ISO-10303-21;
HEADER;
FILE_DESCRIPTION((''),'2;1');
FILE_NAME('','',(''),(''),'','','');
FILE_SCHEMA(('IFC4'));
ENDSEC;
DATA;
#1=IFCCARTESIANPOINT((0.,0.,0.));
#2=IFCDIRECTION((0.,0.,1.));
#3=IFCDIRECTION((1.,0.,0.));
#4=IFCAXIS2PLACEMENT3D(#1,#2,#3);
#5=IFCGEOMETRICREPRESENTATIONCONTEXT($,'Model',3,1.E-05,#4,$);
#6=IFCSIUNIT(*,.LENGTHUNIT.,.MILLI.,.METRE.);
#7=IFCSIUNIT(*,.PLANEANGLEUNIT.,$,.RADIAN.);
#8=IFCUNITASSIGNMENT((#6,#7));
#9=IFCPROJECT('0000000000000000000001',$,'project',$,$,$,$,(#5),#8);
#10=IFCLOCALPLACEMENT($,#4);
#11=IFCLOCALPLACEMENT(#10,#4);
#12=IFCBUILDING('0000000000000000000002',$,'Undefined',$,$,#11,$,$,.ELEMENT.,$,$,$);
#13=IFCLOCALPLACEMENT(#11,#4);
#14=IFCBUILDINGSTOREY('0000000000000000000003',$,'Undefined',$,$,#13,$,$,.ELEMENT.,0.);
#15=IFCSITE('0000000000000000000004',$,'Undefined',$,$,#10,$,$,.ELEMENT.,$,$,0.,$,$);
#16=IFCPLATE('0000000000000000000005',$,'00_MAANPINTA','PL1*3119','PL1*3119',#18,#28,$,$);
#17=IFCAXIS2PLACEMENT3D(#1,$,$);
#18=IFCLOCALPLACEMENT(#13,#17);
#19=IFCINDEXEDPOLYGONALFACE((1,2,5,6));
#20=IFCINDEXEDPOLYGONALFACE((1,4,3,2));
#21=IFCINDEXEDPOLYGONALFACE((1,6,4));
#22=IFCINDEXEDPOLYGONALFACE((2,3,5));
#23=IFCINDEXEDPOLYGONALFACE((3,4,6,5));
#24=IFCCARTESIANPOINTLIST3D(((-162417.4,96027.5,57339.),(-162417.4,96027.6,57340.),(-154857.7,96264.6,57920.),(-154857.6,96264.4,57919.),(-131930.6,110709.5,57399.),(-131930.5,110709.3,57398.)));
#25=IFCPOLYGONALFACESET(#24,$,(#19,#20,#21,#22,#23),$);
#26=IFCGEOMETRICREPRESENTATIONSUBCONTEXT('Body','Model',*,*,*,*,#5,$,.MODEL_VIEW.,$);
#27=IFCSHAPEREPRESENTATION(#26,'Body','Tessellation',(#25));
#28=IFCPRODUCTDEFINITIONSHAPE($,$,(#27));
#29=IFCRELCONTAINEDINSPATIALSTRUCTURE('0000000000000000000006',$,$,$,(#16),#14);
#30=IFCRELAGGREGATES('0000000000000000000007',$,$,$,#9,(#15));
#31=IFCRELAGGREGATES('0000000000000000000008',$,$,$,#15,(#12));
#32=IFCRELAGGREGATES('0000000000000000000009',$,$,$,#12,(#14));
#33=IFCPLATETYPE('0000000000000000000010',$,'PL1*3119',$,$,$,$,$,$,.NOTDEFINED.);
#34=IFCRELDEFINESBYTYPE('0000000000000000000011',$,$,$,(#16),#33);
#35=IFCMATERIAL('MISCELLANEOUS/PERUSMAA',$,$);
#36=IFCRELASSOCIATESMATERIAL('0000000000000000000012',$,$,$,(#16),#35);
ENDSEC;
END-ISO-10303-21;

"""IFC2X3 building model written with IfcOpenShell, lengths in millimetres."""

from ifc_helpers import new_model, si_unit, frame, origin_with_axes, place, context, subcontext, project, spatial, polyline, outline, extrude, material, type_object, element, save


model = new_model("IFC2X3")

# Units and contexts
model_context = context("Model", 3, precision=1e-05, world=origin_with_axes())
body_context = subcontext(model_context, "Body", "Model", "MODEL_VIEW")
ifc_project = project(units=[si_unit("LENGTHUNIT", "METRE", prefix="MILLI"), si_unit("PLANEANGLEUNIT", "RADIAN")], contexts=[model_context])

# Site, building, storey
site_placement = place(None, origin_with_axes())
site = spatial("IfcSite", under=ifc_project, at=site_placement, Name="Undefined", CompositionType="ELEMENT", RefElevation=0.0)
building_placement = place(site_placement, origin_with_axes())
building = spatial("IfcBuilding", under=site, at=building_placement, Name="Undefined", CompositionType="ELEMENT")
storey_placement = place(building_placement, origin_with_axes())
storey = spatial("IfcBuildingStorey", under=building, at=storey_placement, Name="Undefined", CompositionType="ELEMENT", Elevation=0.0)

# Plate
ifc_material = material(Name="MISCELLANEOUS/PERUSMAA")
plate_type_1 = type_object("IfcPlateType", Name="PL1*3119", PredefinedType="NOTDEFINED")
plate_1_placement = place(storey_placement, frame((-162417.4, 96027.5, 57339.5), z_axis=(0.080559, -0.163329, -0.983277), x_axis=(0.900965, 0.433888, 0.001744)))
element("IfcPlate", 1, at=plate_1_placement, inside=storey, type_object=plate_type_1, material=ifc_material, Name="00_MAANPINTA", Description="PL1*3119", ObjectType="PL1*3119", context=body_context, shape_type="SweptSolid", body=[
    extrude(outline(polyline([(0.0, 0.0), (33838.0, 0.0), (6914.9, 3118.7), (0.0, 0.0)])), frame((0.0, 0.0, -0.5), z_axis=(0.0, 0.0, 1.0), x_axis=(1.0, 0.0, 0.0)), (0.0, 0.0, 1.0), 1.0),
])

save(model, "model.ifc")
